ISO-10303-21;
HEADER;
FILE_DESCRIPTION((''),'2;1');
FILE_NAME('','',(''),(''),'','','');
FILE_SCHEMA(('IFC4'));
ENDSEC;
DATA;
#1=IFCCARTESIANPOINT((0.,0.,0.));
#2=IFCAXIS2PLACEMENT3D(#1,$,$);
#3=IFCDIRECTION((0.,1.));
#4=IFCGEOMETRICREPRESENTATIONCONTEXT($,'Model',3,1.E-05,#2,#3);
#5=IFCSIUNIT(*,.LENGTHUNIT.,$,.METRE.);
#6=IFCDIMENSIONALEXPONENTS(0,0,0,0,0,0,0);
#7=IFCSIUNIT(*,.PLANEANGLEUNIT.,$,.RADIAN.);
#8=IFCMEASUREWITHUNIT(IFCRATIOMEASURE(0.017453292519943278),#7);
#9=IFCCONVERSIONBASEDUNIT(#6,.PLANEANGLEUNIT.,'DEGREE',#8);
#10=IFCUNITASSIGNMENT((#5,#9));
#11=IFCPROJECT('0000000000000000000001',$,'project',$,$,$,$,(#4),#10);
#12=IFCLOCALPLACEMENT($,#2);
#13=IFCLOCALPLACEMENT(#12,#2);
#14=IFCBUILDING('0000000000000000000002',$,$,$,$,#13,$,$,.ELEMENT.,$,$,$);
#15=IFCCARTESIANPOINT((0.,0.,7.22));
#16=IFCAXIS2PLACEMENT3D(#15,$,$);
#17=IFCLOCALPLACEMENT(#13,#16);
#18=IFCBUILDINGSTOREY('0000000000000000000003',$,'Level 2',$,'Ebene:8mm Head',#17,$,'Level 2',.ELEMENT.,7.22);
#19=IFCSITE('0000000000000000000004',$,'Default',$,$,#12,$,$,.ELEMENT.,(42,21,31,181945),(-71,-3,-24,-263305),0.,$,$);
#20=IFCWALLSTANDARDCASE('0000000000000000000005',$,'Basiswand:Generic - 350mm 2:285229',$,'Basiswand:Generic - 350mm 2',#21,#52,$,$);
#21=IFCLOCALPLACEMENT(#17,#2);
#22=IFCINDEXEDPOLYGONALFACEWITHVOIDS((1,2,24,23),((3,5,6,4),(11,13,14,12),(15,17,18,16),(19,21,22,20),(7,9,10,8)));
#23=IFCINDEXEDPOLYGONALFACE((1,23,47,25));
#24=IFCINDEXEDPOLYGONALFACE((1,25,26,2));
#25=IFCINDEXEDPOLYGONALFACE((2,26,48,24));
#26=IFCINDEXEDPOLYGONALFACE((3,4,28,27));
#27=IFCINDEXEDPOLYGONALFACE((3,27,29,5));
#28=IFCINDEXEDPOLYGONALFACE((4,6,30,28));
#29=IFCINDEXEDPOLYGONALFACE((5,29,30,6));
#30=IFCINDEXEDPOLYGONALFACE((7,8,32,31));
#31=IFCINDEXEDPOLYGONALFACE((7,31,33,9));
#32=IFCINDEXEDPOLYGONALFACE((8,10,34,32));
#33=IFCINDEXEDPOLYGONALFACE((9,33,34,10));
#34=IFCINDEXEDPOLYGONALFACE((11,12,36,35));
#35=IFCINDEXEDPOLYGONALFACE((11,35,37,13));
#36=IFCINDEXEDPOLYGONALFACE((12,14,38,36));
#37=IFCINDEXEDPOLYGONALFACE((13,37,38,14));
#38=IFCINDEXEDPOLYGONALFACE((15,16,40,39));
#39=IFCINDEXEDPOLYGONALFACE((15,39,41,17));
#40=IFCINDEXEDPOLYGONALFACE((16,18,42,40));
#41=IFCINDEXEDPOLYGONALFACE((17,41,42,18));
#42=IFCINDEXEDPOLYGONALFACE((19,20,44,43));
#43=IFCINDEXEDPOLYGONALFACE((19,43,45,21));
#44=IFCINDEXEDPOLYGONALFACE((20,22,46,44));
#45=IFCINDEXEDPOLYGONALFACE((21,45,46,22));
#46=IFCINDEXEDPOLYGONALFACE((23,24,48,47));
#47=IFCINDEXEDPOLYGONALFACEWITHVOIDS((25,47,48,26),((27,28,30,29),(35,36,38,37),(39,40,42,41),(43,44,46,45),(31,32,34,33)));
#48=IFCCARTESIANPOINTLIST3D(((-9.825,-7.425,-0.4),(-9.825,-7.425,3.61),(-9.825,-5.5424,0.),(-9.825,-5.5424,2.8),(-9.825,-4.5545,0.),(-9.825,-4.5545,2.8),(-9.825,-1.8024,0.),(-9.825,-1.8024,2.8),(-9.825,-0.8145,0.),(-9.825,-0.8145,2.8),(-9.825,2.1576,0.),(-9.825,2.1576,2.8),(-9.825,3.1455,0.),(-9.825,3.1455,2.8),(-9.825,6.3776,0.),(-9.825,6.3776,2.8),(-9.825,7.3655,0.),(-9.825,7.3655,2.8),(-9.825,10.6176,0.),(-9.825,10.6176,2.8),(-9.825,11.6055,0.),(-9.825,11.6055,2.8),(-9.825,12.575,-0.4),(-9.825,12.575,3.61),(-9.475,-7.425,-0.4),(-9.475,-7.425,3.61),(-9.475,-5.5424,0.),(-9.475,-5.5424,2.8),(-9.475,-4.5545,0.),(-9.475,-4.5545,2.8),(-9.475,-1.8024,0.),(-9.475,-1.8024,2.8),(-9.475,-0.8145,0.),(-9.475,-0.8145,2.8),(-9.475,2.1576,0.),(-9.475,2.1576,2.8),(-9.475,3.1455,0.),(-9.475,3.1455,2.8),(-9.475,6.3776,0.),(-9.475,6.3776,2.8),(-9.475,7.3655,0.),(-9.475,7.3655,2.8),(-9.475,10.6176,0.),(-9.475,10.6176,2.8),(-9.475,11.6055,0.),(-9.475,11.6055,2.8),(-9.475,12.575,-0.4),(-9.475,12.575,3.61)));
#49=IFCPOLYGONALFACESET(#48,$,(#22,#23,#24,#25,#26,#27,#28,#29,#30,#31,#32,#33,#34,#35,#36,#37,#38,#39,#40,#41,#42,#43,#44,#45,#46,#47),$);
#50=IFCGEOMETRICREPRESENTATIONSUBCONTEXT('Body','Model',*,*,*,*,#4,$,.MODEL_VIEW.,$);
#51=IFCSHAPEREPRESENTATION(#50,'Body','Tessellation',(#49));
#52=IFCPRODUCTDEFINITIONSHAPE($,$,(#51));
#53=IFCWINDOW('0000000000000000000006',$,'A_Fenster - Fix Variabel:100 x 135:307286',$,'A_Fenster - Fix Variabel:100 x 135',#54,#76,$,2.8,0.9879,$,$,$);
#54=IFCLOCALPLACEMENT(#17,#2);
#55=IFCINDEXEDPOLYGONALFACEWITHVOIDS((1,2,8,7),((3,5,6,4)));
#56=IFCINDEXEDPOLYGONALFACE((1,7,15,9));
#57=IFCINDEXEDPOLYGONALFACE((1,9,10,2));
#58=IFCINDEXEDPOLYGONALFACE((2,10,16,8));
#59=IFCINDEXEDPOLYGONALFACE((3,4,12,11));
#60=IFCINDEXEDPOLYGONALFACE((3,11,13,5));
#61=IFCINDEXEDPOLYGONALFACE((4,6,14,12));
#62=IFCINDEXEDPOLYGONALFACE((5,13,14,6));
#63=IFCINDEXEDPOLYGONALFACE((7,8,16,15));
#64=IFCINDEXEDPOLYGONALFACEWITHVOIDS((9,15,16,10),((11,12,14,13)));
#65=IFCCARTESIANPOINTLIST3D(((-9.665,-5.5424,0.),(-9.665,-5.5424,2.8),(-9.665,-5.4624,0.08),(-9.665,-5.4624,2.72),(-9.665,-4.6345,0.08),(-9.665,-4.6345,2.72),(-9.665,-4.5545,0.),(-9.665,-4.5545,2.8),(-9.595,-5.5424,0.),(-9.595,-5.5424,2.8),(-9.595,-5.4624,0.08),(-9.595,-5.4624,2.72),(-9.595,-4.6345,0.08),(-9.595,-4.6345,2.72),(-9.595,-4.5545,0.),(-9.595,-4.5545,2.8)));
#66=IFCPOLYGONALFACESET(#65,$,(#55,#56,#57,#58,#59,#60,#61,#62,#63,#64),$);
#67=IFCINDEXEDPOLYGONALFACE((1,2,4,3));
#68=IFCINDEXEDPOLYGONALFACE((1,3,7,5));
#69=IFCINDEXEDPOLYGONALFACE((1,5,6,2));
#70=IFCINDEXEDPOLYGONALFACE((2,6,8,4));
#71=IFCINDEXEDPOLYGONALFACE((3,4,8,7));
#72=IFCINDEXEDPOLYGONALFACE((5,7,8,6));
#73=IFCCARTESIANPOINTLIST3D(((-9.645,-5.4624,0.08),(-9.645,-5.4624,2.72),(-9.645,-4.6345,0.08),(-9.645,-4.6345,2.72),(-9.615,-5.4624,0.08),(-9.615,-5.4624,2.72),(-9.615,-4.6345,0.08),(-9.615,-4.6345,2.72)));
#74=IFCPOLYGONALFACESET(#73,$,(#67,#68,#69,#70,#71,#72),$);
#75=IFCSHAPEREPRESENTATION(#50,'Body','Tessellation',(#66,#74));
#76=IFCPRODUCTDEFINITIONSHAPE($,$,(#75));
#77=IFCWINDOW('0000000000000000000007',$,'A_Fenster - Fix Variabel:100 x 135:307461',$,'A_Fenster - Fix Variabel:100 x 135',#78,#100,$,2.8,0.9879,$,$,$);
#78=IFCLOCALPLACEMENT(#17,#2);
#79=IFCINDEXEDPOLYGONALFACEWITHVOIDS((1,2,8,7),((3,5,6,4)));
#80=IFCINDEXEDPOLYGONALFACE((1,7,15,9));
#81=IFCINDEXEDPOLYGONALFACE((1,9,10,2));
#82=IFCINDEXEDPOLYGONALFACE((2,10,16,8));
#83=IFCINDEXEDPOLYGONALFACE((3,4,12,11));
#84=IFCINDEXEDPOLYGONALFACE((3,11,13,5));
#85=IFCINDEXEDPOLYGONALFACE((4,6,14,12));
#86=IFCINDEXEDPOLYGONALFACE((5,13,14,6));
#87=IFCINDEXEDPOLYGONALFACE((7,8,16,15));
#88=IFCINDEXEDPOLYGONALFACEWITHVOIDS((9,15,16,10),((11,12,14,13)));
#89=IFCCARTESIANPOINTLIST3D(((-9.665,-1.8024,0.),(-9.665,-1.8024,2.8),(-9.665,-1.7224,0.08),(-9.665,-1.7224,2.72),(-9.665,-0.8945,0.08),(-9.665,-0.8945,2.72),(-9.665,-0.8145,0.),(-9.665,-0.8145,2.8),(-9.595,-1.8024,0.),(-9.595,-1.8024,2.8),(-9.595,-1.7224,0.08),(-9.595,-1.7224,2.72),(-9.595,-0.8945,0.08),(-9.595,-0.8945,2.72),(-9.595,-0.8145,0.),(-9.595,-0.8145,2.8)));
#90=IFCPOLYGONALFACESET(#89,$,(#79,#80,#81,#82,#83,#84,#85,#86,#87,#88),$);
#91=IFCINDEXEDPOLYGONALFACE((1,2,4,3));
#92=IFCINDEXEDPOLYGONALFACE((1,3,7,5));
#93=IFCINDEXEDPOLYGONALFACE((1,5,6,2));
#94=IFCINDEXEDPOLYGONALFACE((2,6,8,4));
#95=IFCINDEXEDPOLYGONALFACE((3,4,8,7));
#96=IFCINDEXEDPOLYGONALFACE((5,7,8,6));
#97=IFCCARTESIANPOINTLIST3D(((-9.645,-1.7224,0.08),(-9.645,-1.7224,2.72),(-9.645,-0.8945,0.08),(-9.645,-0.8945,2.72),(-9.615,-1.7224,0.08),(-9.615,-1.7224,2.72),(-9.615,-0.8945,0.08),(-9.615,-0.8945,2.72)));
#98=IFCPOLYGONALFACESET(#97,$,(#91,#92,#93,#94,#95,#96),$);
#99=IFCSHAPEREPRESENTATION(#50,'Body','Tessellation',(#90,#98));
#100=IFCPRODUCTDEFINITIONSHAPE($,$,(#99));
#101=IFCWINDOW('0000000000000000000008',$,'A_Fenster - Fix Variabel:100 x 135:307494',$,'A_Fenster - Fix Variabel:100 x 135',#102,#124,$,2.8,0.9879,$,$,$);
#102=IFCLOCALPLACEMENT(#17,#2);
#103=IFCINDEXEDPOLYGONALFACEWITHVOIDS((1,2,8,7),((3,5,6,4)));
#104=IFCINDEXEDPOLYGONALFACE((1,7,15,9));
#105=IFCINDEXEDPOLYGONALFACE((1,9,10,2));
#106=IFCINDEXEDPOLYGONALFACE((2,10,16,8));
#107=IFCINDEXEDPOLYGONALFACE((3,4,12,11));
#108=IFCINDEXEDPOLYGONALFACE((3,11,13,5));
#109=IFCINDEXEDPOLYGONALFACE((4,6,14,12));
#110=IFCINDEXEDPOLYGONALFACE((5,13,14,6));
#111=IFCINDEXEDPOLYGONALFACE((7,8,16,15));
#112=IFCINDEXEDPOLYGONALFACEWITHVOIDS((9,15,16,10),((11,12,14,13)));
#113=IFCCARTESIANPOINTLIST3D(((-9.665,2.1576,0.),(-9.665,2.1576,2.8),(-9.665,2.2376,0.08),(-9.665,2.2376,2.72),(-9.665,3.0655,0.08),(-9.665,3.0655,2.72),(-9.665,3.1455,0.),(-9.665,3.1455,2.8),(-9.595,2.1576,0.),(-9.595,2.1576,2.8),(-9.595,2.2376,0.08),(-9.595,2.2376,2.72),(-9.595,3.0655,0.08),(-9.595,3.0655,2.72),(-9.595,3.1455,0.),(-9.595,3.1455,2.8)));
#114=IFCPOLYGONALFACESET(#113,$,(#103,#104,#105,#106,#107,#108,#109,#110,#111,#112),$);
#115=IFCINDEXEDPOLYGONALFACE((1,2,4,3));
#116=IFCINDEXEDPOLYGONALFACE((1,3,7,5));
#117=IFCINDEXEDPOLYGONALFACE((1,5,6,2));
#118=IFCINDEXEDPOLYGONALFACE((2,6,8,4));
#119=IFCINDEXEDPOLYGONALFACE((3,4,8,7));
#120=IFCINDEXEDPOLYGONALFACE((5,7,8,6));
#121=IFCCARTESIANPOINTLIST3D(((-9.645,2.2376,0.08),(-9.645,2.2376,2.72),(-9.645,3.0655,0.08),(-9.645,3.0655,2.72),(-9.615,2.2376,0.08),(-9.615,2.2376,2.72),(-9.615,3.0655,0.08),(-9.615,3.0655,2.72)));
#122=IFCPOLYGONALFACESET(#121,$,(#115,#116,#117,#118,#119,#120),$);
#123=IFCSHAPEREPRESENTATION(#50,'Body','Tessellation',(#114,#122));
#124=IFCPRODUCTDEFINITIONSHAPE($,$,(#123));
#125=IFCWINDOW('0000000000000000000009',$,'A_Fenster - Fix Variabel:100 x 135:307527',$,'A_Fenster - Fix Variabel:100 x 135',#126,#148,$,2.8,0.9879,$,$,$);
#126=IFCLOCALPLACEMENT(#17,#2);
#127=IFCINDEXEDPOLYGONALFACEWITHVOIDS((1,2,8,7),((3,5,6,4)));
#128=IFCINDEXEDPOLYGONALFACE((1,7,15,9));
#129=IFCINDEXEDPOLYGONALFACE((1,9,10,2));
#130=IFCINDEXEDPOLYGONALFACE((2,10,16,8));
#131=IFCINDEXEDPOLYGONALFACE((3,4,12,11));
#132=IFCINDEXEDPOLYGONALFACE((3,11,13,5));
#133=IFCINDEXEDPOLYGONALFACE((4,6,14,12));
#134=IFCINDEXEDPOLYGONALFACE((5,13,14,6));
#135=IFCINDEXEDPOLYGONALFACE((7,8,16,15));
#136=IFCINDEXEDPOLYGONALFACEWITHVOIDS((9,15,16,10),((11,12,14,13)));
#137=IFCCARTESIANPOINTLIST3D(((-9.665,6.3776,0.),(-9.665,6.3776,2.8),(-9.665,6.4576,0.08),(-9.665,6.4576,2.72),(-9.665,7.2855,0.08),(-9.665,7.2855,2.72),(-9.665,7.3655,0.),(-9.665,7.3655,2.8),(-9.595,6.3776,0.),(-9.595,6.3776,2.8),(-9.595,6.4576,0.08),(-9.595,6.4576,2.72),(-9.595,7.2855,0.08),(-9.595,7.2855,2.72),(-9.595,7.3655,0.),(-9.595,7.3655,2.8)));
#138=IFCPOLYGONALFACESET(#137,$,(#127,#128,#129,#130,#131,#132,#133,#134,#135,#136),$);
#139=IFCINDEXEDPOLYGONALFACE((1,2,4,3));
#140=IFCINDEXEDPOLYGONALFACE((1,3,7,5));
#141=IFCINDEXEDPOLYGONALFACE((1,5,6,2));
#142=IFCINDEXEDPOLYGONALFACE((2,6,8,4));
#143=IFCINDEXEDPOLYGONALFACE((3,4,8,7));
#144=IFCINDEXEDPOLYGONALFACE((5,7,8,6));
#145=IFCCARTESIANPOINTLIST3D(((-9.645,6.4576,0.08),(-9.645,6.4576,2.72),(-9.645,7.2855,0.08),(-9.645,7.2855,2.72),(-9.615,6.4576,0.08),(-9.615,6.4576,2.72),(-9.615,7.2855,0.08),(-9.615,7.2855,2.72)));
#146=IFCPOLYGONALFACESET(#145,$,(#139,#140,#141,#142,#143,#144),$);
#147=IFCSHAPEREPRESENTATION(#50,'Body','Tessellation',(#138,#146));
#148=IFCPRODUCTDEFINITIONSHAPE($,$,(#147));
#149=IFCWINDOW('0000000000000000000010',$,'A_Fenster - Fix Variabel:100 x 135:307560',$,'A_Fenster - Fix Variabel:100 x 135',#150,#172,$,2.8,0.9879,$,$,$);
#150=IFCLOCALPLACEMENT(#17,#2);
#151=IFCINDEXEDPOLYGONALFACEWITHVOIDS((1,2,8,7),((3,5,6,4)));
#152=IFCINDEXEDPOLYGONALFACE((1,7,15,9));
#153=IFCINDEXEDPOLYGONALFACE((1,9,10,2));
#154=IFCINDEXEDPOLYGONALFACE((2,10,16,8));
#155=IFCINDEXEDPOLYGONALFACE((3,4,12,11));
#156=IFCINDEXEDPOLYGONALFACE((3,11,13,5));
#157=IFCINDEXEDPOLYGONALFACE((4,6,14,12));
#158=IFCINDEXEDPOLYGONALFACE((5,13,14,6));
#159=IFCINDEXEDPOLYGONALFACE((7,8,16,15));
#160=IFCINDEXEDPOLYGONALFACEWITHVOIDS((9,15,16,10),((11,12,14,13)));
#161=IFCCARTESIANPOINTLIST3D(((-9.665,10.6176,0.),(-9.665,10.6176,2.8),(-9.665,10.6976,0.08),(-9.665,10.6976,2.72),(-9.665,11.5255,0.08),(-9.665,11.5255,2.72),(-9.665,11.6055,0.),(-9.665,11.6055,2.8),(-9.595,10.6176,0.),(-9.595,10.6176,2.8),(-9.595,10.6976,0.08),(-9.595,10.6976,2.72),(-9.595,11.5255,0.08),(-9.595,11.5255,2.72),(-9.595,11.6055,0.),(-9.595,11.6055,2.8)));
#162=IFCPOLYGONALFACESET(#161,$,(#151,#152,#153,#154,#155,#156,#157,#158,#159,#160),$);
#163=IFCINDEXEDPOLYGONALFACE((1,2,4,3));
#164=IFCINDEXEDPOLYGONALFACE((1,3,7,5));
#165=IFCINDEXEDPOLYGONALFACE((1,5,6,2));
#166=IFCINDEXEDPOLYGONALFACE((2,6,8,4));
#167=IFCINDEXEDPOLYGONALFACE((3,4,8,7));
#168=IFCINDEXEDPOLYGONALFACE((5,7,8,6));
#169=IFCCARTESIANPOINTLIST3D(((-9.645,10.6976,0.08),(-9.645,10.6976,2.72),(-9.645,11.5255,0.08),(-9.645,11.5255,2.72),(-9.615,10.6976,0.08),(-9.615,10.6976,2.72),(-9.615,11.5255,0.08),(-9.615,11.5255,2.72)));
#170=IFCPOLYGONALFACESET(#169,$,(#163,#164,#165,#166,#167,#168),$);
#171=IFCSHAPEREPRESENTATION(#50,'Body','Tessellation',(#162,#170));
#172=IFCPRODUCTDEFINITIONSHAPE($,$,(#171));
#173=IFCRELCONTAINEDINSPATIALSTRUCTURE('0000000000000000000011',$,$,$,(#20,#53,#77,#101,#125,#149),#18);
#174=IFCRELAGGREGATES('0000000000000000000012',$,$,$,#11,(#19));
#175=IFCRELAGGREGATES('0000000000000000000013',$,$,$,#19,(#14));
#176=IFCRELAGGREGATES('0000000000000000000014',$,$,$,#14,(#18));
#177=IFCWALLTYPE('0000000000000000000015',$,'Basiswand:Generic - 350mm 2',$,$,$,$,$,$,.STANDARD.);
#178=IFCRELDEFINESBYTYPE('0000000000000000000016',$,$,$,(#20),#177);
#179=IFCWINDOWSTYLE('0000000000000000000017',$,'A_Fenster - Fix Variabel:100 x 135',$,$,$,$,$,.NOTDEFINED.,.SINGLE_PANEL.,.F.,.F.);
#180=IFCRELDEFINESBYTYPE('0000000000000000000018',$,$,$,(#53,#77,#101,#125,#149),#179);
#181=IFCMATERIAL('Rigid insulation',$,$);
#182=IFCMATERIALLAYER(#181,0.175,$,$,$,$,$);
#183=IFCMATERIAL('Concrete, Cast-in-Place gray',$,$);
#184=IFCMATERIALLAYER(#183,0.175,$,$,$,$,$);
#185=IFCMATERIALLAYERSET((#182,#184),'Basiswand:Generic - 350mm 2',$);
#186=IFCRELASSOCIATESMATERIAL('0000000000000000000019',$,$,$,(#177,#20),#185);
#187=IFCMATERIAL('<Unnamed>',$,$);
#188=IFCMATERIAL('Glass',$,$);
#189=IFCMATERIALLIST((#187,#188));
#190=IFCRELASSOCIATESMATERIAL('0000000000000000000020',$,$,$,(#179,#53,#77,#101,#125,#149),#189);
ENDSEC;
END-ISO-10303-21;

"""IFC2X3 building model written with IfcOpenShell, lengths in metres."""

from ifc_helpers import new_model, entity, si_unit, converted_unit, direction, frame, frame_2d, origin, origin_2d_with_axis, place, context, subcontext, project, spatial, polyline, rectangle, outline, extrude, source, transform, mapped, material, material_list, layer, layer_set, layer_usage, type_object, type_shapes, element, fill, save


model = new_model("IFC2X3")

# Units and contexts
model_context = context("Model", 3, precision=1e-05, world=origin(), true_north=direction((0.0, 1.0)))
body_context = subcontext(model_context, "Body", "Model", "MODEL_VIEW")
ifc_project = project(units=[si_unit("LENGTHUNIT", "METRE"), converted_unit("PLANEANGLEUNIT", "DEGREE", entity("IfcRatioMeasure", 0.017453292519943278), si_unit("PLANEANGLEUNIT", "RADIAN"), dimensions=[0, 0, 0, 0, 0, 0, 0])], contexts=[model_context])

# Site, building, storey
site_placement = place(None, origin())
site = spatial("IfcSite", under=ifc_project, at=site_placement, Name="Default", CompositionType="ELEMENT", RefLatitude=(42, 21, 31, 181945), RefLongitude=(-71, -3, -24, -263305), RefElevation=0.0)
building_placement = place(site_placement, origin())
building = spatial("IfcBuilding", under=site, at=building_placement, CompositionType="ELEMENT")
storey_placement = place(building_placement, frame((0.0, 0.0, 7.22)))
storey = spatial("IfcBuildingStorey", under=building, at=storey_placement, Name="Level 2", ObjectType="Ebene:8mm Head", LongName="Level 2", CompositionType="ELEMENT", Elevation=7.22)

# Wall, openings, windows
ifc_material_1 = material(Name="Rigid insulation")
ifc_layer_1 = layer(ifc_material_1, 0.175)
ifc_material_2 = material(Name="Concrete, Cast-in-Place gray")
ifc_layer_2 = layer(ifc_material_2, 0.175)
ifc_layer_set = layer_set([ifc_layer_1, ifc_layer_2], Name="Basiswand:Generic - 350mm 2")
wall_type = type_object("IfcWallType", Name="Basiswand:Generic - 350mm 2", PredefinedType="STANDARD", material=ifc_layer_set)
ifc_material_3 = material(Name="<Unnamed>")
ifc_material_4 = material(Name="Glass")
ifc_material_list = material_list([ifc_material_3, ifc_material_4])
ifc_layer_usage_1 = layer_usage(ifc_layer_set, "AXIS2", "NEGATIVE", 0.175)
wall_1_placement = place(storey_placement, frame((-9.65, 12.575, -0.4), z_axis=(0.0, 0.0, 1.0), x_axis=(0.0, -1.0, 0.0)))
wall_1 = element("IfcWallStandardCase", 1, at=wall_1_placement, inside=storey, type_object=wall_type, material=ifc_layer_usage_1, Name="Basiswand:Generic - 350mm 2:285229", ObjectType="Basiswand:Generic - 350mm 2", context=body_context, shape_type="SweptSolid", body=[
    extrude(rectangle(XDim=20.0, YDim=0.35, at=frame_2d((10.0, 0.0), x_axis=(-1.0, 0.0))), origin(), (0.0, 0.0, 1.0), 4.01),
])
opening_1_placement = place(wall_1_placement, frame((18.1174, 0.175, 0.4)))
opening_1 = element("IfcOpeningElement", 2, at=opening_1_placement, cuts=wall_1, ObjectType="Opening", context=body_context, shape_type="SweptSolid", body=[
    extrude(rectangle(XDim=2.8, YDim=0.9879, at=frame_2d((1.4, 0.4939), x_axis=(1.0, 0.0))), frame((0.0, 0.0, 0.0), z_axis=(0.0, -1.0, 0.0), x_axis=(0.0, 0.0, 1.0)), (0.0, 0.0, 1.0), 0.35),
])
opening_2_placement = place(wall_1_placement, frame((14.3774, 0.175, 0.4)))
opening_2 = element("IfcOpeningElement", 3, at=opening_2_placement, cuts=wall_1, ObjectType="Opening", context=body_context, shape_type="SweptSolid", body=[
    extrude(rectangle(XDim=2.8, YDim=0.9879, at=frame_2d((1.4, 0.4939), x_axis=(1.0, 0.0))), frame((0.0, 0.0, 0.0), z_axis=(0.0, -1.0, 0.0), x_axis=(0.0, 0.0, 1.0)), (0.0, 0.0, 1.0), 0.35),
])
opening_3_placement = place(wall_1_placement, frame((10.4174, 0.175, 0.4)))
opening_3 = element("IfcOpeningElement", 4, at=opening_3_placement, cuts=wall_1, ObjectType="Opening", context=body_context, shape_type="SweptSolid", body=[
    extrude(rectangle(XDim=2.8, YDim=0.9879, at=frame_2d((1.4, 0.4939), x_axis=(1.0, 0.0))), frame((0.0, 0.0, 0.0), z_axis=(0.0, -1.0, 0.0), x_axis=(0.0, 0.0, 1.0)), (0.0, 0.0, 1.0), 0.35),
])
opening_4_placement = place(wall_1_placement, frame((6.1974, 0.175, 0.4)))
opening_4 = element("IfcOpeningElement", 5, at=opening_4_placement, cuts=wall_1, ObjectType="Opening", context=body_context, shape_type="SweptSolid", body=[
    extrude(rectangle(XDim=2.8, YDim=0.9879, at=frame_2d((1.4, 0.4939), x_axis=(1.0, 0.0))), frame((0.0, 0.0, 0.0), z_axis=(0.0, -1.0, 0.0), x_axis=(0.0, 0.0, 1.0)), (0.0, 0.0, 1.0), 0.35),
])
opening_5_placement = place(wall_1_placement, frame((1.9574, 0.175, 0.4)))
opening_5 = element("IfcOpeningElement", 6, at=opening_5_placement, cuts=wall_1, ObjectType="Opening", context=body_context, shape_type="SweptSolid", body=[
    extrude(rectangle(XDim=2.8, YDim=0.9879, at=frame_2d((1.4, 0.4939), x_axis=(1.0, 0.0))), frame((0.0, 0.0, 0.0), z_axis=(0.0, -1.0, 0.0), x_axis=(0.0, 0.0, 1.0)), (0.0, 0.0, 1.0), 0.35),
])
window_style_1 = type_object("IfcWindowStyle", Name="A_Fenster - Fix Variabel:100 x 135", ConstructionType="NOTDEFINED", OperationType="SINGLE_PANEL", ParameterTakesPrecedence=False, Sizeable=False, material=ifc_material_list)
shared_shape_1 = source(origin(), body_context, "Body", "SweptSolid", [
    extrude(outline(polyline([(-1.4, -0.4939), (1.4, -0.4939), (1.4, 0.4939), (-1.4, 0.4939), (-1.4, -0.4939)]), holes=[polyline([(-1.32, -0.4139), (-1.32, 0.4139), (1.32, 0.4139), (1.32, -0.4139), (-1.32, -0.4139)])]), frame((0.4939, 0.12, 1.4), z_axis=(0.0, 1.0, 0.0), x_axis=(0.0, 0.0, -1.0)), (0.0, 0.0, 1.0), 0.07),
    extrude(rectangle(XDim=0.03, YDim=0.8279, at=origin_2d_with_axis()), frame((0.4939, 0.155, 0.08), z_axis=(0.0, 0.0, 1.0), x_axis=(0.0, 1.0, 0.0)), (0.0, 0.0, 1.0), 2.64),
])
type_shapes(window_style_1, [shared_shape_1])
window_1_placement = place(opening_1_placement, frame((0.0, 0.0, 0.0), z_axis=(0.0, 0.0, 1.0), x_axis=(-1.0, 0.0, 0.0)))
window_1 = element("IfcWindow", 7, at=window_1_placement, inside=storey, type_object=window_style_1, material=ifc_material_list, Name="A_Fenster - Fix Variabel:100 x 135:307286", ObjectType="A_Fenster - Fix Variabel:100 x 135", OverallHeight=2.8, OverallWidth=0.9879, context=body_context, shape_type="MappedRepresentation", body=[
    mapped(shared_shape_1, transform((0.0, 0.0, 0.0), scale=1.0)),
])
fill(opening_1, window_1)
window_2_placement = place(opening_2_placement, frame((0.0, 0.0, 0.0), z_axis=(0.0, 0.0, 1.0), x_axis=(-1.0, 0.0, 0.0)))
window_2 = element("IfcWindow", 8, at=window_2_placement, inside=storey, type_object=window_style_1, material=ifc_material_list, Name="A_Fenster - Fix Variabel:100 x 135:307461", ObjectType="A_Fenster - Fix Variabel:100 x 135", OverallHeight=2.8, OverallWidth=0.9879, context=body_context, shape_type="MappedRepresentation", body=[
    mapped(shared_shape_1, transform((0.0, 0.0, 0.0), scale=1.0)),
])
fill(opening_2, window_2)
window_3_placement = place(opening_3_placement, frame((0.0, 0.0, 0.0), z_axis=(0.0, 0.0, 1.0), x_axis=(-1.0, 0.0, 0.0)))
window_3 = element("IfcWindow", 9, at=window_3_placement, inside=storey, type_object=window_style_1, material=ifc_material_list, Name="A_Fenster - Fix Variabel:100 x 135:307494", ObjectType="A_Fenster - Fix Variabel:100 x 135", OverallHeight=2.8, OverallWidth=0.9879, context=body_context, shape_type="MappedRepresentation", body=[
    mapped(shared_shape_1, transform((0.0, 0.0, 0.0), scale=1.0)),
])
fill(opening_3, window_3)
window_4_placement = place(opening_4_placement, frame((0.0, 0.0, 0.0), z_axis=(0.0, 0.0, 1.0), x_axis=(-1.0, 0.0, 0.0)))
window_4 = element("IfcWindow", 10, at=window_4_placement, inside=storey, type_object=window_style_1, material=ifc_material_list, Name="A_Fenster - Fix Variabel:100 x 135:307527", ObjectType="A_Fenster - Fix Variabel:100 x 135", OverallHeight=2.8, OverallWidth=0.9879, context=body_context, shape_type="MappedRepresentation", body=[
    mapped(shared_shape_1, transform((0.0, 0.0, 0.0), scale=1.0)),
])
fill(opening_4, window_4)
window_5_placement = place(opening_5_placement, frame((0.0, 0.0, 0.0), z_axis=(0.0, 0.0, 1.0), x_axis=(-1.0, 0.0, 0.0)))
window_5 = element("IfcWindow", 11, at=window_5_placement, inside=storey, type_object=window_style_1, material=ifc_material_list, Name="A_Fenster - Fix Variabel:100 x 135:307560", ObjectType="A_Fenster - Fix Variabel:100 x 135", OverallHeight=2.8, OverallWidth=0.9879, context=body_context, shape_type="MappedRepresentation", body=[
    mapped(shared_shape_1, transform((0.0, 0.0, 0.0), scale=1.0)),
])
fill(opening_5, window_5)

save(model, "model.ifc")
